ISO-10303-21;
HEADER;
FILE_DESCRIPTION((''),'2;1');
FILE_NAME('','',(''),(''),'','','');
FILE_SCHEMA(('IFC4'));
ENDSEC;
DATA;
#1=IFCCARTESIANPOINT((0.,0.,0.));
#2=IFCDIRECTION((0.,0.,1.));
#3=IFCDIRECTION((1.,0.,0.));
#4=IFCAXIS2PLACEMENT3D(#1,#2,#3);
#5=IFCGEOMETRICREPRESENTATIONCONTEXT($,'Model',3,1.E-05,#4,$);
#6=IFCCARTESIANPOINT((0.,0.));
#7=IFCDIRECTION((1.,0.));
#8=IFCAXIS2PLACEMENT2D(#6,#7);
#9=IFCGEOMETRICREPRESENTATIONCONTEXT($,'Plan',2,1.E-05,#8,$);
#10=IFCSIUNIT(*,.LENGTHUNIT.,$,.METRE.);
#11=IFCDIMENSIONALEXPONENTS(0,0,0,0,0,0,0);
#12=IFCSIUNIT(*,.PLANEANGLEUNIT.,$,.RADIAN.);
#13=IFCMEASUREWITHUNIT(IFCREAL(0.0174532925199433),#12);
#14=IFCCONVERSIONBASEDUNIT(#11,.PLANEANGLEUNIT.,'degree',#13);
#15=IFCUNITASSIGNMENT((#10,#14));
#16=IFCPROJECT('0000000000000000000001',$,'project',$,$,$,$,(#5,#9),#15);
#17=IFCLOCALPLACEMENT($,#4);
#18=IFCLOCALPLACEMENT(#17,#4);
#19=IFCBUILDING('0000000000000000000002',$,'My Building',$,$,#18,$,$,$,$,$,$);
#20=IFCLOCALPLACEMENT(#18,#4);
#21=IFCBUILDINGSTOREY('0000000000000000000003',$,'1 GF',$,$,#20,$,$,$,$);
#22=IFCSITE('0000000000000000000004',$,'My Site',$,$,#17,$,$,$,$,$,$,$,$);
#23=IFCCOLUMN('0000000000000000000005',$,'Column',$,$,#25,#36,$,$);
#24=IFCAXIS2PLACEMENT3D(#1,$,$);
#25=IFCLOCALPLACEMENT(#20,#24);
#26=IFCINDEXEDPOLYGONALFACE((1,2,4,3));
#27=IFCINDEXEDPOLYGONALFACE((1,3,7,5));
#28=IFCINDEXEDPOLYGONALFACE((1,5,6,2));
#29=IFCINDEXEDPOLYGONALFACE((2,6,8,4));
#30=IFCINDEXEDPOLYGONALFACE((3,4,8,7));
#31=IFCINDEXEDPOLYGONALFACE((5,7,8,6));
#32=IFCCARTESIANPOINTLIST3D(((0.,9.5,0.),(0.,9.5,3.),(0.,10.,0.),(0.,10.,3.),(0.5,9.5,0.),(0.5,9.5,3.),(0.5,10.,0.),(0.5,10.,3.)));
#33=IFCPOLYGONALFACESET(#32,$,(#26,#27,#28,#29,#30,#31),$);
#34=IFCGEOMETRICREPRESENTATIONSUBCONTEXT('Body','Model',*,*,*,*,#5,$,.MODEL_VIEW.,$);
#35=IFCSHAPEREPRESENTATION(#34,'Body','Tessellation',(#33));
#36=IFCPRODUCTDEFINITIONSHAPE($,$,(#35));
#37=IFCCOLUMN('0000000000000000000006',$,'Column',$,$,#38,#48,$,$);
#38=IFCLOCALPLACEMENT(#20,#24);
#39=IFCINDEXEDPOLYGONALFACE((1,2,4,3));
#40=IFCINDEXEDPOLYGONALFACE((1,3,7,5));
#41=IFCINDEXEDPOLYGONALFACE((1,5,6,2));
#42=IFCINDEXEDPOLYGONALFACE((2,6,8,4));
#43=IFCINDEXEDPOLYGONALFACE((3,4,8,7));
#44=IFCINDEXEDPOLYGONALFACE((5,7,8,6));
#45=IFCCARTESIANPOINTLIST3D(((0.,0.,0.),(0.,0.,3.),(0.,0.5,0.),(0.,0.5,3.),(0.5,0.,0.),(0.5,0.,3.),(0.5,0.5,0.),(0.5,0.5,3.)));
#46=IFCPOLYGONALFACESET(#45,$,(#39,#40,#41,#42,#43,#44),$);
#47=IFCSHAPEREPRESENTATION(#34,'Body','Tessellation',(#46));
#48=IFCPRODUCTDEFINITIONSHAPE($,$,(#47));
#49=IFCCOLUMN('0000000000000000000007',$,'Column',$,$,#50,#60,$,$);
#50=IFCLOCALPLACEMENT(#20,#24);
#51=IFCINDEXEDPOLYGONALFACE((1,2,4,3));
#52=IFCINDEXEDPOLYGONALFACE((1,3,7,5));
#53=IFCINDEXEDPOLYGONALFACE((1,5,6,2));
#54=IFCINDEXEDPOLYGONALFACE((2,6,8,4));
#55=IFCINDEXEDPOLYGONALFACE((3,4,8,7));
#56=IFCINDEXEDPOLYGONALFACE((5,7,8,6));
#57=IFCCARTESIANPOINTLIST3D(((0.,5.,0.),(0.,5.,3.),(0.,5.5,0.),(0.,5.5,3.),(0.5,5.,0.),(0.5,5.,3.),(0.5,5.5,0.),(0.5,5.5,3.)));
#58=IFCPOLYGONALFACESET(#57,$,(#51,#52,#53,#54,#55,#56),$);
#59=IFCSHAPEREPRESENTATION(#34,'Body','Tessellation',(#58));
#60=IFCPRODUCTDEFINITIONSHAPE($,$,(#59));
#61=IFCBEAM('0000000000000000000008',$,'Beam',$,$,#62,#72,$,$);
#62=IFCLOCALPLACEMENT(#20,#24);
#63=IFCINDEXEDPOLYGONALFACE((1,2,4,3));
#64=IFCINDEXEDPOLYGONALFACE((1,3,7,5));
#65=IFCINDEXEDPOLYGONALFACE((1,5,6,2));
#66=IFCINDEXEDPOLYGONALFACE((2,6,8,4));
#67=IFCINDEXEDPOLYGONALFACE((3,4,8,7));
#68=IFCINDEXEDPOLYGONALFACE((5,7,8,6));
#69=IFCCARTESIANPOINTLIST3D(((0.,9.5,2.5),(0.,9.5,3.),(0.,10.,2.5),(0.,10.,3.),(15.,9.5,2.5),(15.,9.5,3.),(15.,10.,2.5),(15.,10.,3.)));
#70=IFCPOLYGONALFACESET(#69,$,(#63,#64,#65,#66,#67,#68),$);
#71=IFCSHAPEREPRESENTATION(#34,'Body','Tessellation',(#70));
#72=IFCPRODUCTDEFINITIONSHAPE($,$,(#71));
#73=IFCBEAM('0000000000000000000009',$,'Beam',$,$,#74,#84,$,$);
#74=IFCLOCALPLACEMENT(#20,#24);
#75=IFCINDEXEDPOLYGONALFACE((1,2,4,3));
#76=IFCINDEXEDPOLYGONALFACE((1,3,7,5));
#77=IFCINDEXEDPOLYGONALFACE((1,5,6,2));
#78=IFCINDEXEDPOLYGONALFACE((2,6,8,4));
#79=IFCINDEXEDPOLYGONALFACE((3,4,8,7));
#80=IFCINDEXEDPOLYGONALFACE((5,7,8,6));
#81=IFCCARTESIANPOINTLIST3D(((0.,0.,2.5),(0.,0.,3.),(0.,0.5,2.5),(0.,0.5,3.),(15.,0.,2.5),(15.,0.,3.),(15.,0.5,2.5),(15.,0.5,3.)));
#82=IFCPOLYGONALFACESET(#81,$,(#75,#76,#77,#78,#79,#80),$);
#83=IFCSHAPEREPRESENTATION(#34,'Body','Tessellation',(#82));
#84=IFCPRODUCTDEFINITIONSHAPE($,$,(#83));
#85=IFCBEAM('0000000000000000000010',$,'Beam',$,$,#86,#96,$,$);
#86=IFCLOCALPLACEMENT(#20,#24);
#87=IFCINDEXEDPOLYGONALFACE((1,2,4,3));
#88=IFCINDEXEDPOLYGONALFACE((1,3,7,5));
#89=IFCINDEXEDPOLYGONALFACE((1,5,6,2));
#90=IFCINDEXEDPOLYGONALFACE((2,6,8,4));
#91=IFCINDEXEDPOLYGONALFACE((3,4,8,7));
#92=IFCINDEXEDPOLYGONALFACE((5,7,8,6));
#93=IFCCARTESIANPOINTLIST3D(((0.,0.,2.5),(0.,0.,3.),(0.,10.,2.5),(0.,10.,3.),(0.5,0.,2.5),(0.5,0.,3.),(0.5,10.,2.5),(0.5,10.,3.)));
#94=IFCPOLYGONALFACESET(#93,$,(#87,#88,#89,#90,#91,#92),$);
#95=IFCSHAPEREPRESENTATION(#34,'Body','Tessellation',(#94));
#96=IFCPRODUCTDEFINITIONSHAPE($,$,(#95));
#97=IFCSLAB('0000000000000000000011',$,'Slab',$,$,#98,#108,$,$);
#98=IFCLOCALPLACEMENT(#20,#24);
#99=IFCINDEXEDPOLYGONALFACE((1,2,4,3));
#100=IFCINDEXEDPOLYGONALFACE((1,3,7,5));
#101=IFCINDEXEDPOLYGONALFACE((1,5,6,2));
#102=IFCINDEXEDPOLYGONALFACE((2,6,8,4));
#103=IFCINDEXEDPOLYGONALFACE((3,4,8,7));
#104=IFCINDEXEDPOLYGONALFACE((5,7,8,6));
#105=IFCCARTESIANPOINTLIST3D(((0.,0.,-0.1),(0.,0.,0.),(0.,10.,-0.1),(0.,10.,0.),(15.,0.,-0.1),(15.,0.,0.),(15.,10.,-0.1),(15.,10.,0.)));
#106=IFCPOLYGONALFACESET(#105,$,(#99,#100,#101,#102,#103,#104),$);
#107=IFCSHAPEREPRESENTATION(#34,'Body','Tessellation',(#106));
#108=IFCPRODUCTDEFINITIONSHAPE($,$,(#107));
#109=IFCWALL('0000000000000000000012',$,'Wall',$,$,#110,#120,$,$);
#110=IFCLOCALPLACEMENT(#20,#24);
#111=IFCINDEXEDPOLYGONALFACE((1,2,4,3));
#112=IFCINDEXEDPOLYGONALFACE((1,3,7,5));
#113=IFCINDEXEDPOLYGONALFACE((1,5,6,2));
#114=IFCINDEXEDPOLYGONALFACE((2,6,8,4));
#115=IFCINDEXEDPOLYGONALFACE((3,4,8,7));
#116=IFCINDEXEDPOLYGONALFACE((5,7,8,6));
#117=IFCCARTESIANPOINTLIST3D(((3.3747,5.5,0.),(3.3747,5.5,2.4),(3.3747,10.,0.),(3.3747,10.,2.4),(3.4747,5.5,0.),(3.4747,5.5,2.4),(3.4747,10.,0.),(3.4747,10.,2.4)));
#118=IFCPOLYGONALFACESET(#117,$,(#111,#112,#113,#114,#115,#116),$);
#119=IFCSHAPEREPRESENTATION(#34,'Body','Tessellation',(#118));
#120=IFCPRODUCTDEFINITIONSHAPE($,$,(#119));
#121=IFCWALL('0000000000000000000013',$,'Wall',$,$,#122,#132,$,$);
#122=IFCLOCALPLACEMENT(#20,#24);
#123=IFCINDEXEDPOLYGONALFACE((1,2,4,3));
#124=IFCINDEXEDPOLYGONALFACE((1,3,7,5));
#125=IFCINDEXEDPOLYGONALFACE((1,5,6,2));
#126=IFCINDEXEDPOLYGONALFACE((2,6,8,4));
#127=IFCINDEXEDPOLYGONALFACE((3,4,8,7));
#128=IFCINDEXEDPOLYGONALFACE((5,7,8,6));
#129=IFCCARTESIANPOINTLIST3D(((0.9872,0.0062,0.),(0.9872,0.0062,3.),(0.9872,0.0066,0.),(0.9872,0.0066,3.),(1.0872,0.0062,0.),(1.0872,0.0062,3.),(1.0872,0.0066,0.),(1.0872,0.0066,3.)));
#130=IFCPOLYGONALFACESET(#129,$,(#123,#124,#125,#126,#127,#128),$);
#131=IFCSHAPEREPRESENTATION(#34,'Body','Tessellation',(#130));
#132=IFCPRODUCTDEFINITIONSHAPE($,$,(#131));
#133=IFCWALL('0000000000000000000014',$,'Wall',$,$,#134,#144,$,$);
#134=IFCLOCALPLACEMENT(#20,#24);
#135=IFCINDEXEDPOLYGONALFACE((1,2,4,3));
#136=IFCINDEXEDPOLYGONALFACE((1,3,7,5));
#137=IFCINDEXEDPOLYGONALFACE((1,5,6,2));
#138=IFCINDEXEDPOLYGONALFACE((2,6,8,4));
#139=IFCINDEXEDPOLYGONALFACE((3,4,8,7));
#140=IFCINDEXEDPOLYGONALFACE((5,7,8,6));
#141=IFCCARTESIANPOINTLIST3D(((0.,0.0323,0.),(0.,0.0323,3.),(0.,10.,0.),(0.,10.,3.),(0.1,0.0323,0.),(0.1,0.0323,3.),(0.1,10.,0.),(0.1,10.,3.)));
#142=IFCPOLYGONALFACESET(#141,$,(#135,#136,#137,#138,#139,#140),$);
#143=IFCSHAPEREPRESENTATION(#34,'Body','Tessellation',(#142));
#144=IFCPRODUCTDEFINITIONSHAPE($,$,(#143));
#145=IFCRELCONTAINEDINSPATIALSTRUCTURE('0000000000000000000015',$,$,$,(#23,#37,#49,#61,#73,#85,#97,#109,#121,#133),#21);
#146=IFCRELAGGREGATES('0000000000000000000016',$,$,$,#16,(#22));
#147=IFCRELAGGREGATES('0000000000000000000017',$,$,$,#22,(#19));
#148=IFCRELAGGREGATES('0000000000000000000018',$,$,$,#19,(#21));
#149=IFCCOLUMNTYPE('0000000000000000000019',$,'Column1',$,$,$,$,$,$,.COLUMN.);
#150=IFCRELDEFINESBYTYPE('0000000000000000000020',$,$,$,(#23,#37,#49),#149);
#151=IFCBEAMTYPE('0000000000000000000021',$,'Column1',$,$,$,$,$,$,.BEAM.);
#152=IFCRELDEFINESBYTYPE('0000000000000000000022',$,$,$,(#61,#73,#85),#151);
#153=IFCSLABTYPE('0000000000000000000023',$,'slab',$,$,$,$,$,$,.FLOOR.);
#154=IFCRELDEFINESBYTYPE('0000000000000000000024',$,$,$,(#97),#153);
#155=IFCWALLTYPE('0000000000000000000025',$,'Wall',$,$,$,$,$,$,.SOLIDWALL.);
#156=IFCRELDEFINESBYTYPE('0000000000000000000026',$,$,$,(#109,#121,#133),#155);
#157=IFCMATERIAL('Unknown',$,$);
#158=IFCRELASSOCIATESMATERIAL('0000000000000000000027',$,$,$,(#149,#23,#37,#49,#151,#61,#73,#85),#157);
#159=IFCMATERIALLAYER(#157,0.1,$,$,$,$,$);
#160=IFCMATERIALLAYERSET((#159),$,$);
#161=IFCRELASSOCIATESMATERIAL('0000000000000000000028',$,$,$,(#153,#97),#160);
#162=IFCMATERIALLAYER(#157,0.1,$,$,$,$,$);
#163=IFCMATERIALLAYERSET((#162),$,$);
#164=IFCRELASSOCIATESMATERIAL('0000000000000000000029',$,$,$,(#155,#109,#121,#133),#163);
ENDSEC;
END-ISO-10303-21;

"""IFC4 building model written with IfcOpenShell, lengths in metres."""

from ifc_helpers import new_model, entity, si_unit, converted_unit, frame, origin_with_axes, origin_2d_with_axis, place, context, subcontext, project, spatial, line, indexed_curve, rectangle, outline, extrude, material, layer, layer_set, layer_usage, material_profile, profile_set, profile_usage, type_object, element, save


model = new_model("IFC4")

# Units and contexts
model_context = context("Model", 3, precision=1e-05, world=origin_with_axes())
plan_context = context("Plan", 2, precision=1e-05, world=origin_2d_with_axis())
body_context_1 = subcontext(model_context, "Body", "Model", "MODEL_VIEW")
ifc_project = project(units=[si_unit("LENGTHUNIT", "METRE"), converted_unit("PLANEANGLEUNIT", "degree", entity("IfcReal", 0.0174532925199433), si_unit("PLANEANGLEUNIT", "RADIAN"), dimensions=[0, 0, 0, 0, 0, 0, 0])], contexts=[model_context, plan_context])

# Site, building, storey
site_placement = place(None, origin_with_axes())
site = spatial("IfcSite", under=ifc_project, at=site_placement, Name="My Site")
building_placement = place(site_placement, origin_with_axes())
building = spatial("IfcBuilding", under=site, at=building_placement, Name="My Building")
storey_placement = place(building_placement, origin_with_axes())
storey = spatial("IfcBuildingStorey", under=building, at=storey_placement, Name="1 GF")

# Columns
ifc_material = material(Name="Unknown")
ifc_material_profile_1 = material_profile(ifc_material, rectangle(XDim=0.5, YDim=0.5))
ifc_profile_set_1 = profile_set([ifc_material_profile_1])
ifc_profile_usage_1 = profile_usage(ifc_profile_set_1, cardinal=1)
column_type = type_object("IfcColumnType", Name="Column1", PredefinedType="COLUMN", material=ifc_profile_set_1)
column_1_placement = place(storey_placement, frame((0.5, 9.5, 0.0), z_axis=(0.0, 0.0, 1.0), x_axis=(1.0, 0.0, 0.0)))
element("IfcColumn", 1, at=column_1_placement, inside=storey, type_object=column_type, material=ifc_profile_usage_1, Name="Column", context=body_context_1, shape_type="SweptSolid", body=[
    extrude(rectangle(XDim=0.5, YDim=0.5), frame((-0.25, 0.25, 0.0), z_axis=(0.0, 0.0, 1.0), x_axis=(1.0, 0.0, 0.0)), (0.0, 0.0, 1.0), 3.0),
])
ifc_profile_usage_2 = profile_usage(ifc_profile_set_1, cardinal=1)
column_2_placement = place(storey_placement, frame((0.5, 0.0, 0.0), z_axis=(0.0, 0.0, 1.0), x_axis=(1.0, 0.0, 0.0)))
element("IfcColumn", 2, at=column_2_placement, inside=storey, type_object=column_type, material=ifc_profile_usage_2, Name="Column", context=body_context_1, shape_type="SweptSolid", body=[
    extrude(rectangle(XDim=0.5, YDim=0.5), frame((-0.25, 0.25, 0.0), z_axis=(0.0, 0.0, 1.0), x_axis=(1.0, 0.0, 0.0)), (0.0, 0.0, 1.0), 3.0),
])
ifc_profile_usage_3 = profile_usage(ifc_profile_set_1, cardinal=1)
column_3_placement = place(storey_placement, frame((0.5, 5.0, 0.0), z_axis=(0.0, 0.0, 1.0), x_axis=(1.0, 0.0, 0.0)))
element("IfcColumn", 3, at=column_3_placement, inside=storey, type_object=column_type, material=ifc_profile_usage_3, Name="Column", context=body_context_1, shape_type="SweptSolid", body=[
    extrude(rectangle(XDim=0.5, YDim=0.5), frame((-0.25, 0.25, 0.0), z_axis=(0.0, 0.0, 1.0), x_axis=(1.0, 0.0, 0.0)), (0.0, 0.0, 1.0), 3.0),
])

# Beams
ifc_material_profile_2 = material_profile(ifc_material, rectangle(XDim=0.5, YDim=0.5))
ifc_profile_set_2 = profile_set([ifc_material_profile_2])
ifc_profile_usage_4 = profile_usage(ifc_profile_set_2, cardinal=7)
beam_type = type_object("IfcBeamType", Name="Column1", PredefinedType="BEAM", material=ifc_profile_set_2)
beam_1_placement = place(storey_placement, frame((0.0, 10.0, 3.0), z_axis=(1.0, 0.0, 0.0), x_axis=(0.0, 1.0, 0.0)))
element("IfcBeam", 4, at=beam_1_placement, inside=storey, type_object=beam_type, material=ifc_profile_usage_4, Name="Beam", context=body_context_1, shape_type="SweptSolid", body=[
    extrude(rectangle(XDim=0.5, YDim=0.5), frame((-0.25, -0.25, 0.0), z_axis=(0.0, 0.0, 1.0), x_axis=(1.0, 0.0, 0.0)), (0.0, 0.0, 1.0), 15.0),
])
ifc_profile_usage_5 = profile_usage(ifc_profile_set_2, cardinal=7)
beam_2_placement = place(storey_placement, frame((0.0, 0.5, 3.0), z_axis=(1.0, 0.0, 0.0), x_axis=(0.0, 1.0, 0.0)))
element("IfcBeam", 5, at=beam_2_placement, inside=storey, type_object=beam_type, material=ifc_profile_usage_5, Name="Beam", context=body_context_1, shape_type="SweptSolid", body=[
    extrude(rectangle(XDim=0.5, YDim=0.5), frame((-0.25, -0.25, 0.0), z_axis=(0.0, 0.0, 1.0), x_axis=(1.0, 0.0, 0.0)), (0.0, 0.0, 1.0), 15.0),
])
ifc_profile_usage_6 = profile_usage(ifc_profile_set_2, cardinal=7)
beam_3_placement = place(storey_placement, frame((0.5, 10.0, 3.0), z_axis=(0.0, -1.0, 0.0), x_axis=(1.0, 0.0, 0.0)))
element("IfcBeam", 6, at=beam_3_placement, inside=storey, type_object=beam_type, material=ifc_profile_usage_6, Name="Beam", context=body_context_1, shape_type="SweptSolid", body=[
    extrude(rectangle(XDim=0.5, YDim=0.5), frame((-0.25, -0.25, 0.0), z_axis=(0.0, 0.0, 1.0), x_axis=(1.0, 0.0, 0.0)), (0.0, 0.0, 1.0), 10.0),
])

# Slab
ifc_layer_1 = layer(ifc_material, 0.1)
ifc_layer_set_1 = layer_set([ifc_layer_1])
ifc_layer_usage_1 = layer_usage(ifc_layer_set_1, "AXIS3", "POSITIVE", -0.1)
slab_type = type_object("IfcSlabType", Name="slab", PredefinedType="FLOOR", material=ifc_layer_set_1)
slab_placement = place(storey_placement, frame((0.0, 10.0, 0.0), z_axis=(0.0, 0.0, 1.0), x_axis=(1.0, 0.0, 0.0)))
element("IfcSlab", 7, at=slab_placement, inside=storey, type_object=slab_type, material=ifc_layer_usage_1, Name="Slab", context=body_context_1, shape_type="SweptSolid", body=[
    extrude(outline(indexed_curve([(0.0, 0.0), (0.0, -10.0), (15.0, -10.0), (15.0, 0.0), (0.0, 0.0)])), frame((0.0, 0.0, -0.1), z_axis=(0.0, 0.0, 1.0), x_axis=(1.0, 0.0, 0.0)), (0.0, 0.0, 1.0), 0.1),
])

# Shared definitions
ifc_layer_2 = layer(ifc_material, 0.1)
ifc_layer_set_2 = layer_set([ifc_layer_2])
wall_type = type_object("IfcWallType", Name="Wall", PredefinedType="SOLIDWALL", material=ifc_layer_set_2)

# Walls
ifc_layer_usage_2 = layer_usage(ifc_layer_set_2, "AXIS2", "POSITIVE", 0.0)
wall_1_placement = place(storey_placement, frame((3.4747, 5.5, 0.0), z_axis=(0.0, 0.0, 1.0), x_axis=(0.0, 1.0, 0.0)))
element("IfcWall", 8, at=wall_1_placement, inside=storey, type_object=wall_type, material=ifc_layer_usage_2, Name="Wall", context=body_context_1, shape_type="SweptSolid", body=[
    extrude(outline(indexed_curve([(0.0, 0.0), (0.0, 0.1), (4.5, 0.1), (4.5, 0.0)], segments=[line(1, 2, 3, 4, 1)])), origin_with_axes(), (0.0, 0.0, 1.0), 2.4),
])
ifc_layer_usage_3 = layer_usage(ifc_layer_set_2, "AXIS2", "POSITIVE", 0.0)
wall_2_placement = place(storey_placement, frame((0.9872, 0.0066, 0.0), z_axis=(0.0, 0.0, 1.0), x_axis=(0.0, -1.0, 0.0)))
element("IfcWall", 9, at=wall_2_placement, inside=storey, type_object=wall_type, material=ifc_layer_usage_3, Name="Wall", context=body_context_1, shape_type="SweptSolid", body=[
    extrude(outline(indexed_curve([(0.0, 0.0), (0.0, 0.1), (0.0005, 0.1), (0.0005, 0.0)], segments=[line(1, 2, 3, 4, 1)])), origin_with_axes(), (0.0, 0.0, 1.0), 3.0),
])
ifc_layer_usage_4 = layer_usage(ifc_layer_set_2, "AXIS2", "POSITIVE", 0.0)
wall_3_placement = place(storey_placement, frame((0.0, 10.0, 0.0), z_axis=(0.0, 0.0, 1.0), x_axis=(0.0, -1.0, 0.0)))
element("IfcWall", 10, at=wall_3_placement, inside=storey, type_object=wall_type, material=ifc_layer_usage_4, Name="Wall", context=body_context_1, shape_type="SweptSolid", body=[
    extrude(outline(indexed_curve([(0.0, 0.0), (0.0, 0.1), (9.9677, 0.1), (9.9677, 0.0)], segments=[line(1, 2, 3, 4, 1)])), origin_with_axes(), (0.0, 0.0, 1.0), 3.0),
])

save(model, "model.ifc")
